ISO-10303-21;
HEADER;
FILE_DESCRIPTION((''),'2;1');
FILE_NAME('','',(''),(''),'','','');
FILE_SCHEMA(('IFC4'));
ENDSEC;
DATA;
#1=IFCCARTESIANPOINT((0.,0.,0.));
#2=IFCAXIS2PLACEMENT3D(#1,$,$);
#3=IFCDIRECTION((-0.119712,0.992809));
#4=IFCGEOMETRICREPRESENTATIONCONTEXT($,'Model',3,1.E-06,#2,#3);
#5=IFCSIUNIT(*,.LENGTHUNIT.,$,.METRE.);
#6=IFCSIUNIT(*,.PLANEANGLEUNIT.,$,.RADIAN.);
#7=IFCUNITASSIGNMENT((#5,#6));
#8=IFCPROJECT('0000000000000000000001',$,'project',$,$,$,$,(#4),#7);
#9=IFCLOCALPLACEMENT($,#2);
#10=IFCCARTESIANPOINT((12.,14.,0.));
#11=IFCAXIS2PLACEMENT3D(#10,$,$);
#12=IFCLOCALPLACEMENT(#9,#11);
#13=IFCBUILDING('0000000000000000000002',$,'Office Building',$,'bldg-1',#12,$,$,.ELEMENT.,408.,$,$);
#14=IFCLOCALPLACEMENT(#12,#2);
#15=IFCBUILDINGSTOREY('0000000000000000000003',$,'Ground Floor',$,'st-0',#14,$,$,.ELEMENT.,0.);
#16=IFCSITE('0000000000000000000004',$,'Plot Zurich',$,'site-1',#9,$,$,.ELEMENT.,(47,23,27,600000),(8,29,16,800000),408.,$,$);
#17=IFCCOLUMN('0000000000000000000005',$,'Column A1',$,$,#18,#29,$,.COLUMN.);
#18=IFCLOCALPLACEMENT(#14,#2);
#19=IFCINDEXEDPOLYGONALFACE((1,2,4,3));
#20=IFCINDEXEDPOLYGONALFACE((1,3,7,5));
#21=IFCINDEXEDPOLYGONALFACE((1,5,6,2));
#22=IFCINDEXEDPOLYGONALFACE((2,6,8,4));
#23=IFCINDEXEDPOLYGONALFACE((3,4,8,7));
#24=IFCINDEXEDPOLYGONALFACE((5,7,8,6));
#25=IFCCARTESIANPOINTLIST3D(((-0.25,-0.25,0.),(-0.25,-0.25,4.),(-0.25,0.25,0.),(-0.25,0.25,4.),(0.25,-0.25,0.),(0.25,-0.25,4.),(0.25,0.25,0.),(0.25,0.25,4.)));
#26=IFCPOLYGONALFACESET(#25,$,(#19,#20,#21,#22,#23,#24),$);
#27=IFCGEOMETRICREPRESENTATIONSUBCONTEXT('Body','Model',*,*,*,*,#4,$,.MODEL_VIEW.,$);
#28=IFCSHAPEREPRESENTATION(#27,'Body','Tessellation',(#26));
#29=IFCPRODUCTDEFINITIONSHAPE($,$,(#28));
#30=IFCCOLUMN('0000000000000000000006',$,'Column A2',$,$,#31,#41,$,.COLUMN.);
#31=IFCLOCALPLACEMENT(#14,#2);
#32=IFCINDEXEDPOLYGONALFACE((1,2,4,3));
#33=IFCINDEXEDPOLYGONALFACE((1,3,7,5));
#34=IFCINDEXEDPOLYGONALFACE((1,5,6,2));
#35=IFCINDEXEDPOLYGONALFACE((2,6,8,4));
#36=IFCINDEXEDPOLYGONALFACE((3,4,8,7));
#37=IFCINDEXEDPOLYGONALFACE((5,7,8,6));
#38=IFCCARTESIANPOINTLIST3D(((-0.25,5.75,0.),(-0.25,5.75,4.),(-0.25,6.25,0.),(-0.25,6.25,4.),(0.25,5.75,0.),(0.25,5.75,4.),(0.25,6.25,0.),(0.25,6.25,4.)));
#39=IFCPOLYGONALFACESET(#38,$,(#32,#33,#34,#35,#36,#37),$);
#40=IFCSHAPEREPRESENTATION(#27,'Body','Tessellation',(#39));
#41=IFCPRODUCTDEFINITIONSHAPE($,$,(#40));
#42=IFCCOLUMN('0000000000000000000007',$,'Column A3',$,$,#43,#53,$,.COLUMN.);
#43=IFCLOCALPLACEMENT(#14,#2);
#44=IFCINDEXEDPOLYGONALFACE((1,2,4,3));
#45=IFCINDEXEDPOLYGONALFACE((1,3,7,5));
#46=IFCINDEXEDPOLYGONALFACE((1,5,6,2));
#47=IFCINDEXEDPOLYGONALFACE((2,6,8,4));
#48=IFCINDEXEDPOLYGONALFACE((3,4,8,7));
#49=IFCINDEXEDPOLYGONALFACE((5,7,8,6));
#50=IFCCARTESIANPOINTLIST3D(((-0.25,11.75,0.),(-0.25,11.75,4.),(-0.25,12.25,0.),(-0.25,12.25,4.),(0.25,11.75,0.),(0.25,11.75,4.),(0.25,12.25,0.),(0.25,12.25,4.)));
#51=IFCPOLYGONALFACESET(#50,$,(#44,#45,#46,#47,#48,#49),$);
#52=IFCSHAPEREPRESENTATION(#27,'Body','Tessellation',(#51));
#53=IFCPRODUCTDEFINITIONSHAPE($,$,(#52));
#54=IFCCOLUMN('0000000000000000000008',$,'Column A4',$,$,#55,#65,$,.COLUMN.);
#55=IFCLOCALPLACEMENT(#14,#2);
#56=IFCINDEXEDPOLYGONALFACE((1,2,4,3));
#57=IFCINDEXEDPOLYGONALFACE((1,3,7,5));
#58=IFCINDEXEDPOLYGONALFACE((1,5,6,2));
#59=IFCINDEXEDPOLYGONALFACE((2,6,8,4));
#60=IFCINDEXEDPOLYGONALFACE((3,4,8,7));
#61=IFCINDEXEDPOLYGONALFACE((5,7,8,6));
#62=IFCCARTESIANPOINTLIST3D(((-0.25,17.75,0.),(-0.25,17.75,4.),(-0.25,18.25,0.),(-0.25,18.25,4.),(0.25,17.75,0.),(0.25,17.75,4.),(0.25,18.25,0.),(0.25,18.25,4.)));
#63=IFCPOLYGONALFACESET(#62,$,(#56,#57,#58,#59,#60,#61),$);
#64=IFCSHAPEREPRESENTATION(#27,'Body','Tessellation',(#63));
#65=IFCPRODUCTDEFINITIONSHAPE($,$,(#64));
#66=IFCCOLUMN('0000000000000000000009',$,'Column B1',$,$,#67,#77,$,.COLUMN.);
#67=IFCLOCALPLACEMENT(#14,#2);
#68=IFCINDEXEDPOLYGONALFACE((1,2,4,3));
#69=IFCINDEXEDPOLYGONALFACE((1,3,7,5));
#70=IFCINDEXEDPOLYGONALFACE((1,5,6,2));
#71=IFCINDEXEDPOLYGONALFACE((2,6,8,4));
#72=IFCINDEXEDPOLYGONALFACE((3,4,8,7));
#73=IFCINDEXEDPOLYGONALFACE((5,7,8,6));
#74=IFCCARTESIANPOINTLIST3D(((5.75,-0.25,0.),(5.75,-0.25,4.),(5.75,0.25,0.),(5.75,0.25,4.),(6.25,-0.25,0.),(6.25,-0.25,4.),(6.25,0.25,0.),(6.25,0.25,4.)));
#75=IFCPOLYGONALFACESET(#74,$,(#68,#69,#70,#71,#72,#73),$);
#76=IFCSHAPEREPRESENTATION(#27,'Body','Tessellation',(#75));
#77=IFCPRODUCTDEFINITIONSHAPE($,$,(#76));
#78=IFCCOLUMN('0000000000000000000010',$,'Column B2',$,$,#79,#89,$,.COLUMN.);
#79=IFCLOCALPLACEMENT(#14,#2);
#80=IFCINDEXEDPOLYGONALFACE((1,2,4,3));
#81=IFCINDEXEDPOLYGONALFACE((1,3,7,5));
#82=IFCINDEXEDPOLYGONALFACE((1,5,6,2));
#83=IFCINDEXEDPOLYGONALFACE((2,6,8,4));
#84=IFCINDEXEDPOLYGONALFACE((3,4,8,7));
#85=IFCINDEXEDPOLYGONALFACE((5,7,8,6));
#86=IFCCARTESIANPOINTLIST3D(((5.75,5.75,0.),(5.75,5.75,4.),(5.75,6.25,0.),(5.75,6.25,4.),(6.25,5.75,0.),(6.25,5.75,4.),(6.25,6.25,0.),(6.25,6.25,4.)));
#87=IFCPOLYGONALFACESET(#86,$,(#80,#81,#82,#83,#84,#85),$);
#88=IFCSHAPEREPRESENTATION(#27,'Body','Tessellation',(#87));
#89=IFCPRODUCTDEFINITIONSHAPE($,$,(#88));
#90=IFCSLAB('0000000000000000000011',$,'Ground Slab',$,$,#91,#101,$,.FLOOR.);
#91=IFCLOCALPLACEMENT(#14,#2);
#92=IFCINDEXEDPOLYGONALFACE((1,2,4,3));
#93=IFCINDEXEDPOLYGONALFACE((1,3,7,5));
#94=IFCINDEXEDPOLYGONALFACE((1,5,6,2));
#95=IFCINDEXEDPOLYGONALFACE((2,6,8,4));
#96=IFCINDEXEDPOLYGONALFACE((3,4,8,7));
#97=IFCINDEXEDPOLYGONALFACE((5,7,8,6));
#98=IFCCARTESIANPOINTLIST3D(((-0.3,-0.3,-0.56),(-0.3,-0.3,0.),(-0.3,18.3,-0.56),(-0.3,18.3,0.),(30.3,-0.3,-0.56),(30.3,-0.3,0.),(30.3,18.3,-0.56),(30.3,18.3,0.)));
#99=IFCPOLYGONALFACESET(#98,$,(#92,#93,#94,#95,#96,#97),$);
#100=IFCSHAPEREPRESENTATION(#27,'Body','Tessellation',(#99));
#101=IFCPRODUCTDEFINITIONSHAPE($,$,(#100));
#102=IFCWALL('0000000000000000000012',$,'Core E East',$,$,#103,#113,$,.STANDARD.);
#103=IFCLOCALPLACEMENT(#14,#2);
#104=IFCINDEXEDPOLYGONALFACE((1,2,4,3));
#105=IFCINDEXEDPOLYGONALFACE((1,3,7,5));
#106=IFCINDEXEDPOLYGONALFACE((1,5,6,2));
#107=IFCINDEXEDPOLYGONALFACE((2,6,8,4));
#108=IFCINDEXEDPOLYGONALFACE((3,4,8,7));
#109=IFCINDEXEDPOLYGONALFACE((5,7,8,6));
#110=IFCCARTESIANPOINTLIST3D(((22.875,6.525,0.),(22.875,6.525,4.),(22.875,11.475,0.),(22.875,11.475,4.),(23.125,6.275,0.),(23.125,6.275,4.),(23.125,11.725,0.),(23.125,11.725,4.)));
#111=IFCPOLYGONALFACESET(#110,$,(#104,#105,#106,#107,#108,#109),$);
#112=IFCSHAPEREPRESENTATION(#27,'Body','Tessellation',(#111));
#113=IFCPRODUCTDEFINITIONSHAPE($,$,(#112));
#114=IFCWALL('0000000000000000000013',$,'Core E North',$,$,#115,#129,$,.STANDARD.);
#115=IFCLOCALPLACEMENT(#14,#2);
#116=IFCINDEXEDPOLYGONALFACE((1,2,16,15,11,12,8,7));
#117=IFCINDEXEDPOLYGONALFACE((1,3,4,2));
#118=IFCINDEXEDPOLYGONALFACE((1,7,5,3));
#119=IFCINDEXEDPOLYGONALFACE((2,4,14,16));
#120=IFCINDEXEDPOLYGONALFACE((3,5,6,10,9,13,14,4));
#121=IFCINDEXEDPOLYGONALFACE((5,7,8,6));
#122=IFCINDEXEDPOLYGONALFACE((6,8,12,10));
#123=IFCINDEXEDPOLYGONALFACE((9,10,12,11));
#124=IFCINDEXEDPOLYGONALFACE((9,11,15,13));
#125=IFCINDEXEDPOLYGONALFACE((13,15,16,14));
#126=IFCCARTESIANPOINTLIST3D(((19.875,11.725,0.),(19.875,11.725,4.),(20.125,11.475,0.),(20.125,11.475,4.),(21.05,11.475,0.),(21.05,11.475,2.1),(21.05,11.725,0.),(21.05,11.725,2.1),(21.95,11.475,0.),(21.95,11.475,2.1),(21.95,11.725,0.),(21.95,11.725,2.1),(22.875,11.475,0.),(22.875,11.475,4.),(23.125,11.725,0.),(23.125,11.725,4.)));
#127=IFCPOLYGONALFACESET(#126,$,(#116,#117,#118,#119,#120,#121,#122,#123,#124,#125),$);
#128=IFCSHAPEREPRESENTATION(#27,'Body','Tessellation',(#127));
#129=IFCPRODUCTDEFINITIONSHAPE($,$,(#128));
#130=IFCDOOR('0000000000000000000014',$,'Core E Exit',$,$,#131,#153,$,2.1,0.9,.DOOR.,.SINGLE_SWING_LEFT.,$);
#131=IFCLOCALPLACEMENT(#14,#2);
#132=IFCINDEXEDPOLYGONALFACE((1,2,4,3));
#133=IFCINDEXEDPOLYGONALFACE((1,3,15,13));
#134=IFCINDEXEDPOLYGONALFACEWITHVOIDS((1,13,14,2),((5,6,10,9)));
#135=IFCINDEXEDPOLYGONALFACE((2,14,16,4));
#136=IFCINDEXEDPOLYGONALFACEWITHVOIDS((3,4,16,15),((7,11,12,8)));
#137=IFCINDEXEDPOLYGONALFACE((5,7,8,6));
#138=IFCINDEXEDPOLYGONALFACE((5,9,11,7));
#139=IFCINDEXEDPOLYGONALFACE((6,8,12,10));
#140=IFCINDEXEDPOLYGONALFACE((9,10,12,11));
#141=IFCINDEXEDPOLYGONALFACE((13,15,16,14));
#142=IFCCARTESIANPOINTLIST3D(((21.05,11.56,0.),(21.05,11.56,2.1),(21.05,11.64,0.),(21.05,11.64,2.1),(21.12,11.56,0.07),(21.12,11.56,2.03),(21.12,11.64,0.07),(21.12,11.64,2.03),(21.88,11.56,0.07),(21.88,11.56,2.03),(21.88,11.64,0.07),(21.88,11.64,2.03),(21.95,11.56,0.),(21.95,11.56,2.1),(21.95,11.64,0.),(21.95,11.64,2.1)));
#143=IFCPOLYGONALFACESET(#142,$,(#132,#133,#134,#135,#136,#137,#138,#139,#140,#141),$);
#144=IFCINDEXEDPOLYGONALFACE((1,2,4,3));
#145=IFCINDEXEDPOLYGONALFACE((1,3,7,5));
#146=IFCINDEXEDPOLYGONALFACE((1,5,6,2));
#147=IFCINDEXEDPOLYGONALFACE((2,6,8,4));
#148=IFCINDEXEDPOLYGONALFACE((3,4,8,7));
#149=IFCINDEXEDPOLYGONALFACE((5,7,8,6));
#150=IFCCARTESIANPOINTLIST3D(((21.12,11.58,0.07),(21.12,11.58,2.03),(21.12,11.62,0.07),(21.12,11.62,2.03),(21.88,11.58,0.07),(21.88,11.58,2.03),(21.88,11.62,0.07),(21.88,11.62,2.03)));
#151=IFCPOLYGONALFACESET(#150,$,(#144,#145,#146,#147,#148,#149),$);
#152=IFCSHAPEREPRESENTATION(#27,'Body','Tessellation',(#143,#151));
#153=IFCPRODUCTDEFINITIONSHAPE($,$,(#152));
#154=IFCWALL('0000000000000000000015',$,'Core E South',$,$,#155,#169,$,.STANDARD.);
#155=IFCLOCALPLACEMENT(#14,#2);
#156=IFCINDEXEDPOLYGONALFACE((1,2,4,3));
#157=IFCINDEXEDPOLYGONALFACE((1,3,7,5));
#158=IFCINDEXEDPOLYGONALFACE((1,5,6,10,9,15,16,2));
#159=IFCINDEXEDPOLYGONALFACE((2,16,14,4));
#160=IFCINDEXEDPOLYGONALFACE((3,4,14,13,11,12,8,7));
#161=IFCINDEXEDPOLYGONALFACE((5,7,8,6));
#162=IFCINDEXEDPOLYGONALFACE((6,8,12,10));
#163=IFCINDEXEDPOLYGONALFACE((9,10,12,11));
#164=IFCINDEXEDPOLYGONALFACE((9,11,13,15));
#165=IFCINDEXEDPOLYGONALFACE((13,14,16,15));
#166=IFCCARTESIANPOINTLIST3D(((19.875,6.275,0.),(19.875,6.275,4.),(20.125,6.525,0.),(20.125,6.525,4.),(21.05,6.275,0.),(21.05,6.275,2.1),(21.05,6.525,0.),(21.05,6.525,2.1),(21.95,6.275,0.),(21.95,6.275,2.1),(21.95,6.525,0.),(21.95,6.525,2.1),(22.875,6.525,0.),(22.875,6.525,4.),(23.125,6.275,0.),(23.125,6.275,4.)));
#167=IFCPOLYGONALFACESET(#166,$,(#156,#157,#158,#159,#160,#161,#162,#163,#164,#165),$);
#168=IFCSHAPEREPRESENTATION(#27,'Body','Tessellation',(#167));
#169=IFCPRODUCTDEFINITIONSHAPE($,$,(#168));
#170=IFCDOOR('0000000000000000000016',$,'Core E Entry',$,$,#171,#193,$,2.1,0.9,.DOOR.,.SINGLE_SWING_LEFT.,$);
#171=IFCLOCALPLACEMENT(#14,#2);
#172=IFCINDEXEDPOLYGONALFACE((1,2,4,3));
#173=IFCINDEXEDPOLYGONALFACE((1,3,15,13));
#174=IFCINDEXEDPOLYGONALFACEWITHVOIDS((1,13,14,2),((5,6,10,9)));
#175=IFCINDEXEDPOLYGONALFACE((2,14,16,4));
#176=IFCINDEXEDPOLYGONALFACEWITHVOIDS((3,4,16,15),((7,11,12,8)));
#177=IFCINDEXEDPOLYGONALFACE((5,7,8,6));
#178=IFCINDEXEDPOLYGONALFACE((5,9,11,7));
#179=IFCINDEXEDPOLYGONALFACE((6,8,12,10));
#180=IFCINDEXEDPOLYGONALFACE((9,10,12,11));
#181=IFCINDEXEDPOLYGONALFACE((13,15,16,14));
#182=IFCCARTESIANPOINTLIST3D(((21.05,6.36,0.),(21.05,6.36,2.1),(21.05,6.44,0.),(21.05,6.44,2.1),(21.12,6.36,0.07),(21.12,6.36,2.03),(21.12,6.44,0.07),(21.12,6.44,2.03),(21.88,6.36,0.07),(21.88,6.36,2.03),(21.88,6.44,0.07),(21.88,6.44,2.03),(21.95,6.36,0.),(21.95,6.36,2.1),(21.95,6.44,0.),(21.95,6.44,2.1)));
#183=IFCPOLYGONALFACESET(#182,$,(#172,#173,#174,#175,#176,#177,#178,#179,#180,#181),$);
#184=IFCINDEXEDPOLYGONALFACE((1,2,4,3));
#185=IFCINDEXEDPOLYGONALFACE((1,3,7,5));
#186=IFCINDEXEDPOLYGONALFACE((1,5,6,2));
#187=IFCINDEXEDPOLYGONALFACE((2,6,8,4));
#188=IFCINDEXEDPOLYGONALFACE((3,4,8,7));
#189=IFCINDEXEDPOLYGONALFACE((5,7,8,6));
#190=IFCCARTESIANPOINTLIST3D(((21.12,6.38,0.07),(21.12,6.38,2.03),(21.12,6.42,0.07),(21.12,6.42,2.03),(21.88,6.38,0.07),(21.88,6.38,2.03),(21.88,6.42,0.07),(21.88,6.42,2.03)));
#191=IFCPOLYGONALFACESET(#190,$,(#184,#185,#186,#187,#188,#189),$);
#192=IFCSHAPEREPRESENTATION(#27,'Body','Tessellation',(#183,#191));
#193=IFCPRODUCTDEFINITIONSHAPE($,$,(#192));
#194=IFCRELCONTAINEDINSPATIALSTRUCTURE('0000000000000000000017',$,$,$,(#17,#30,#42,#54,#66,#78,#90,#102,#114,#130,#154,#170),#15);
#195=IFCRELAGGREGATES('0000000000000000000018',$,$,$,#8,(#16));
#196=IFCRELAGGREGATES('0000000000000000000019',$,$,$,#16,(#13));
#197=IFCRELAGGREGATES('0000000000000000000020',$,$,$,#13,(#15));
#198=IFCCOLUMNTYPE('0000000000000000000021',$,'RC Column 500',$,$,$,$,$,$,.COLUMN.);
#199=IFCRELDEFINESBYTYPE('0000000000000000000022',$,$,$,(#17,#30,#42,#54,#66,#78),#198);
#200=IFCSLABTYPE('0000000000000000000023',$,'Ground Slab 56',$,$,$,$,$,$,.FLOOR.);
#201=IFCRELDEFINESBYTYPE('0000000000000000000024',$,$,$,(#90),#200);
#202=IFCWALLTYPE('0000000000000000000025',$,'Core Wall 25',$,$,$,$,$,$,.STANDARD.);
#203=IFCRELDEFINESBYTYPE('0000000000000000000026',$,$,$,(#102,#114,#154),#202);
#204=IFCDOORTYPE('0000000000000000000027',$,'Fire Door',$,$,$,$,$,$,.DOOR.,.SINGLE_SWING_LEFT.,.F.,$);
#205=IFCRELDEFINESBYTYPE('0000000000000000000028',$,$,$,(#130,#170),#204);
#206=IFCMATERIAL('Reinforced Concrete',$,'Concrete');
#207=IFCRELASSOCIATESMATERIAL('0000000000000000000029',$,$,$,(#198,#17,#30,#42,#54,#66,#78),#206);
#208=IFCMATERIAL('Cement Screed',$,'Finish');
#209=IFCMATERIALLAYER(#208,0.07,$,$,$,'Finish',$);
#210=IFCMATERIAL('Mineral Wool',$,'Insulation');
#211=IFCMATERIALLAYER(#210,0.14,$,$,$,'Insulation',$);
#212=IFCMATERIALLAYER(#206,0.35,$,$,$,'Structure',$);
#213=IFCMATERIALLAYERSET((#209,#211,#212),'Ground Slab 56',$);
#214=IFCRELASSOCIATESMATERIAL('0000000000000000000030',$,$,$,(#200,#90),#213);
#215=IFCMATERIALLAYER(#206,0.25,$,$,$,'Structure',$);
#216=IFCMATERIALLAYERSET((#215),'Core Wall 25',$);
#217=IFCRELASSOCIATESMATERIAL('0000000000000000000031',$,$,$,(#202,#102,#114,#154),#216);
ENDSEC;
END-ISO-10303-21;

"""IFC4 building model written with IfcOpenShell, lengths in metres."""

from ifc_helpers import new_model, si_unit, direction, frame, frame_2d, origin, origin_2d, place, context, subcontext, project, spatial, polyline, rectangle, outline, extrude, material, layer, layer_set, layer_usage, type_object, element, fill, save


model = new_model("IFC4")

# Units and contexts
model_context = context("Model", 3, precision=1e-06, world=origin(), true_north=direction((-0.119712, 0.992809)))
body_context = subcontext(model_context, "Body", "Model", "MODEL_VIEW")
ifc_project = project(units=[si_unit("LENGTHUNIT", "METRE"), si_unit("PLANEANGLEUNIT", "RADIAN")], contexts=[model_context])

# Site, building, storey
site_placement = place(None, origin())
site = spatial("IfcSite", under=ifc_project, at=site_placement, Name="Plot Zurich", ObjectType="site-1", CompositionType="ELEMENT", RefLatitude=(47, 23, 27, 600000), RefLongitude=(8, 29, 16, 800000), RefElevation=408.0)
building_placement = place(site_placement, frame((12.0, 14.0, 0.0)))
building = spatial("IfcBuilding", under=site, at=building_placement, Name="Office Building", ObjectType="bldg-1", CompositionType="ELEMENT", ElevationOfRefHeight=408.0)
storey_placement = place(building_placement, origin())
storey = spatial("IfcBuildingStorey", under=building, at=storey_placement, Name="Ground Floor", ObjectType="st-0", CompositionType="ELEMENT", Elevation=0.0)

# Columns
ifc_material_1 = material(Name="Reinforced Concrete", Category="Concrete")
column_type = type_object("IfcColumnType", Name="RC Column 500", PredefinedType="COLUMN", material=ifc_material_1)
for number, where, name in (
    (1, (0.0, 0.0, 0.0), "Column A1"),
    (2, (0.0, 6.0, 0.0), "Column A2"),
    (3, (0.0, 12.0, 0.0), "Column A3"),
    (4, (0.0, 18.0, 0.0), "Column A4"),
    (5, (6.0, 0.0, 0.0), "Column B1"),
    (6, (6.0, 6.0, 0.0), "Column B2"),
):
    element("IfcColumn", number, at=place(storey_placement, frame(where)), inside=storey, type_object=column_type, material=ifc_material_1, Name=name, PredefinedType="COLUMN", context=body_context, shape_type="SweptSolid", body=[
        extrude(rectangle(XDim=0.5, YDim=0.5, at=origin_2d()), origin(), (0.0, 0.0, 1.0), 4.0),
    ])

# Slab
ifc_material_2 = material(Name="Cement Screed", Category="Finish")
ifc_layer_1 = layer(ifc_material_2, 0.07, Category="Finish")
ifc_material_3 = material(Name="Mineral Wool", Category="Insulation")
ifc_layer_2 = layer(ifc_material_3, 0.14, Category="Insulation")
ifc_layer_3 = layer(ifc_material_1, 0.35, Category="Structure")
ifc_layer_set_1 = layer_set([ifc_layer_1, ifc_layer_2, ifc_layer_3], Name="Ground Slab 56")
ifc_layer_usage_1 = layer_usage(ifc_layer_set_1, "AXIS3", "NEGATIVE", 0.56)
slab_type = type_object("IfcSlabType", Name="Ground Slab 56", PredefinedType="FLOOR", material=ifc_layer_set_1)
slab_placement = place(storey_placement, frame((0.0, 0.0, -0.56)))
element("IfcSlab", 7, at=slab_placement, inside=storey, type_object=slab_type, material=ifc_layer_usage_1, Name="Ground Slab", PredefinedType="FLOOR", context=body_context, shape_type="SweptSolid", body=[
    extrude(outline(polyline([(-0.3, -0.3), (30.3, -0.3), (30.3, 18.3), (-0.3, 18.3), (-0.3, -0.3)])), origin(), (0.0, 0.0, 1.0), 0.56),
])

# Wall
ifc_layer_4 = layer(ifc_material_1, 0.25, Category="Structure")
ifc_layer_set_2 = layer_set([ifc_layer_4], Name="Core Wall 25")
ifc_layer_usage_2 = layer_usage(ifc_layer_set_2, "AXIS2", "NEGATIVE", 0.125)
wall_type_1 = type_object("IfcWallType", Name="Core Wall 25", PredefinedType="STANDARD", material=ifc_layer_set_2)
wall_1_placement = place(storey_placement, origin())
element("IfcWall", 8, at=wall_1_placement, inside=storey, type_object=wall_type_1, material=ifc_layer_usage_2, Name="Core E East", PredefinedType="STANDARD", context=body_context, shape_type="SweptSolid", body=[
    extrude(outline(polyline([(23.125, 6.275), (23.125, 11.725), (22.875, 11.475), (22.875, 6.525), (23.125, 6.275)])), origin(), (0.0, 0.0, 1.0), 4.0),
])

# Walls, openings, doors
ifc_layer_usage_3 = layer_usage(ifc_layer_set_2, "AXIS2", "NEGATIVE", 0.125)
wall_2_placement = place(storey_placement, origin())
wall_2 = element("IfcWall", 9, at=wall_2_placement, inside=storey, type_object=wall_type_1, material=ifc_layer_usage_3, Name="Core E North", PredefinedType="STANDARD", context=body_context, shape_type="SweptSolid", body=[
    extrude(outline(polyline([(23.125, 11.725), (19.875, 11.725), (20.125, 11.475), (22.875, 11.475), (23.125, 11.725)])), origin(), (0.0, 0.0, 1.0), 4.0),
])
opening_1_placement = place(wall_2_placement, frame((21.5, 11.6, 0.0), z_axis=(0.0, 0.0, 1.0), x_axis=(-1.0, 0.0, 0.0)))
opening_1 = element("IfcOpeningElement", 10, at=opening_1_placement, cuts=wall_2, PredefinedType="OPENING", context=body_context, shape_type="SweptSolid", body=[
    extrude(rectangle(XDim=0.9, YDim=0.25, at=origin_2d()), origin(), (0.0, 0.0, 1.0), 2.1),
])
door_type = type_object("IfcDoorType", Name="Fire Door", OperationType="SINGLE_SWING_LEFT", ParameterTakesPrecedence=False, PredefinedType="DOOR")
door_1_placement = place(opening_1_placement, frame((0.0, 0.0, 0.0), z_axis=(0.0, -1.0, 0.0), x_axis=(1.0, 0.0, 0.0)))
door_1 = element("IfcDoor", 11, at=door_1_placement, inside=storey, type_object=door_type, Name="Core E Exit", OperationType="SINGLE_SWING_LEFT", OverallHeight=2.1, OverallWidth=0.9, PredefinedType="DOOR", context=body_context, shape_type="SweptSolid", body=[
    extrude(outline(polyline([(-0.45, 0.0), (0.45, 0.0), (0.45, 2.1), (-0.45, 2.1), (-0.45, 0.0)]), holes=[polyline([(-0.38, 0.07), (0.38, 0.07), (0.38, 2.03), (-0.38, 2.03), (-0.38, 0.07)])]), frame((0.0, 0.0, -0.04)), (0.0, 0.0, 1.0), 0.08),
    extrude(rectangle(XDim=0.76, YDim=1.96, at=frame_2d((0.0, 1.05))), frame((0.0, 0.0, -0.02)), (0.0, 0.0, 1.0), 0.04),
])
fill(opening_1, door_1)
ifc_layer_usage_4 = layer_usage(ifc_layer_set_2, "AXIS2", "NEGATIVE", 0.125)
wall_3_placement = place(storey_placement, origin())
wall_3 = element("IfcWall", 12, at=wall_3_placement, inside=storey, type_object=wall_type_1, material=ifc_layer_usage_4, Name="Core E South", PredefinedType="STANDARD", context=body_context, shape_type="SweptSolid", body=[
    extrude(outline(polyline([(19.875, 6.275), (23.125, 6.275), (22.875, 6.525), (20.125, 6.525), (19.875, 6.275)])), origin(), (0.0, 0.0, 1.0), 4.0),
])
opening_2_placement = place(wall_3_placement, frame((21.5, 6.4, 0.0), z_axis=(0.0, 0.0, 1.0), x_axis=(1.0, 0.0, 0.0)))
opening_2 = element("IfcOpeningElement", 13, at=opening_2_placement, cuts=wall_3, PredefinedType="OPENING", context=body_context, shape_type="SweptSolid", body=[
    extrude(rectangle(XDim=0.9, YDim=0.25, at=origin_2d()), origin(), (0.0, 0.0, 1.0), 2.1),
])
door_2_placement = place(opening_2_placement, frame((0.0, 0.0, 0.0), z_axis=(0.0, -1.0, 0.0), x_axis=(1.0, 0.0, 0.0)))
door_2 = element("IfcDoor", 14, at=door_2_placement, inside=storey, type_object=door_type, Name="Core E Entry", OperationType="SINGLE_SWING_LEFT", OverallHeight=2.1, OverallWidth=0.9, PredefinedType="DOOR", context=body_context, shape_type="SweptSolid", body=[
    extrude(outline(polyline([(-0.45, 0.0), (0.45, 0.0), (0.45, 2.1), (-0.45, 2.1), (-0.45, 0.0)]), holes=[polyline([(-0.38, 0.07), (0.38, 0.07), (0.38, 2.03), (-0.38, 2.03), (-0.38, 0.07)])]), frame((0.0, 0.0, -0.04)), (0.0, 0.0, 1.0), 0.08),
    extrude(rectangle(XDim=0.76, YDim=1.96, at=frame_2d((0.0, 1.05))), frame((0.0, 0.0, -0.02)), (0.0, 0.0, 1.0), 0.04),
])
fill(opening_2, door_2)

save(model, "model.ifc")
